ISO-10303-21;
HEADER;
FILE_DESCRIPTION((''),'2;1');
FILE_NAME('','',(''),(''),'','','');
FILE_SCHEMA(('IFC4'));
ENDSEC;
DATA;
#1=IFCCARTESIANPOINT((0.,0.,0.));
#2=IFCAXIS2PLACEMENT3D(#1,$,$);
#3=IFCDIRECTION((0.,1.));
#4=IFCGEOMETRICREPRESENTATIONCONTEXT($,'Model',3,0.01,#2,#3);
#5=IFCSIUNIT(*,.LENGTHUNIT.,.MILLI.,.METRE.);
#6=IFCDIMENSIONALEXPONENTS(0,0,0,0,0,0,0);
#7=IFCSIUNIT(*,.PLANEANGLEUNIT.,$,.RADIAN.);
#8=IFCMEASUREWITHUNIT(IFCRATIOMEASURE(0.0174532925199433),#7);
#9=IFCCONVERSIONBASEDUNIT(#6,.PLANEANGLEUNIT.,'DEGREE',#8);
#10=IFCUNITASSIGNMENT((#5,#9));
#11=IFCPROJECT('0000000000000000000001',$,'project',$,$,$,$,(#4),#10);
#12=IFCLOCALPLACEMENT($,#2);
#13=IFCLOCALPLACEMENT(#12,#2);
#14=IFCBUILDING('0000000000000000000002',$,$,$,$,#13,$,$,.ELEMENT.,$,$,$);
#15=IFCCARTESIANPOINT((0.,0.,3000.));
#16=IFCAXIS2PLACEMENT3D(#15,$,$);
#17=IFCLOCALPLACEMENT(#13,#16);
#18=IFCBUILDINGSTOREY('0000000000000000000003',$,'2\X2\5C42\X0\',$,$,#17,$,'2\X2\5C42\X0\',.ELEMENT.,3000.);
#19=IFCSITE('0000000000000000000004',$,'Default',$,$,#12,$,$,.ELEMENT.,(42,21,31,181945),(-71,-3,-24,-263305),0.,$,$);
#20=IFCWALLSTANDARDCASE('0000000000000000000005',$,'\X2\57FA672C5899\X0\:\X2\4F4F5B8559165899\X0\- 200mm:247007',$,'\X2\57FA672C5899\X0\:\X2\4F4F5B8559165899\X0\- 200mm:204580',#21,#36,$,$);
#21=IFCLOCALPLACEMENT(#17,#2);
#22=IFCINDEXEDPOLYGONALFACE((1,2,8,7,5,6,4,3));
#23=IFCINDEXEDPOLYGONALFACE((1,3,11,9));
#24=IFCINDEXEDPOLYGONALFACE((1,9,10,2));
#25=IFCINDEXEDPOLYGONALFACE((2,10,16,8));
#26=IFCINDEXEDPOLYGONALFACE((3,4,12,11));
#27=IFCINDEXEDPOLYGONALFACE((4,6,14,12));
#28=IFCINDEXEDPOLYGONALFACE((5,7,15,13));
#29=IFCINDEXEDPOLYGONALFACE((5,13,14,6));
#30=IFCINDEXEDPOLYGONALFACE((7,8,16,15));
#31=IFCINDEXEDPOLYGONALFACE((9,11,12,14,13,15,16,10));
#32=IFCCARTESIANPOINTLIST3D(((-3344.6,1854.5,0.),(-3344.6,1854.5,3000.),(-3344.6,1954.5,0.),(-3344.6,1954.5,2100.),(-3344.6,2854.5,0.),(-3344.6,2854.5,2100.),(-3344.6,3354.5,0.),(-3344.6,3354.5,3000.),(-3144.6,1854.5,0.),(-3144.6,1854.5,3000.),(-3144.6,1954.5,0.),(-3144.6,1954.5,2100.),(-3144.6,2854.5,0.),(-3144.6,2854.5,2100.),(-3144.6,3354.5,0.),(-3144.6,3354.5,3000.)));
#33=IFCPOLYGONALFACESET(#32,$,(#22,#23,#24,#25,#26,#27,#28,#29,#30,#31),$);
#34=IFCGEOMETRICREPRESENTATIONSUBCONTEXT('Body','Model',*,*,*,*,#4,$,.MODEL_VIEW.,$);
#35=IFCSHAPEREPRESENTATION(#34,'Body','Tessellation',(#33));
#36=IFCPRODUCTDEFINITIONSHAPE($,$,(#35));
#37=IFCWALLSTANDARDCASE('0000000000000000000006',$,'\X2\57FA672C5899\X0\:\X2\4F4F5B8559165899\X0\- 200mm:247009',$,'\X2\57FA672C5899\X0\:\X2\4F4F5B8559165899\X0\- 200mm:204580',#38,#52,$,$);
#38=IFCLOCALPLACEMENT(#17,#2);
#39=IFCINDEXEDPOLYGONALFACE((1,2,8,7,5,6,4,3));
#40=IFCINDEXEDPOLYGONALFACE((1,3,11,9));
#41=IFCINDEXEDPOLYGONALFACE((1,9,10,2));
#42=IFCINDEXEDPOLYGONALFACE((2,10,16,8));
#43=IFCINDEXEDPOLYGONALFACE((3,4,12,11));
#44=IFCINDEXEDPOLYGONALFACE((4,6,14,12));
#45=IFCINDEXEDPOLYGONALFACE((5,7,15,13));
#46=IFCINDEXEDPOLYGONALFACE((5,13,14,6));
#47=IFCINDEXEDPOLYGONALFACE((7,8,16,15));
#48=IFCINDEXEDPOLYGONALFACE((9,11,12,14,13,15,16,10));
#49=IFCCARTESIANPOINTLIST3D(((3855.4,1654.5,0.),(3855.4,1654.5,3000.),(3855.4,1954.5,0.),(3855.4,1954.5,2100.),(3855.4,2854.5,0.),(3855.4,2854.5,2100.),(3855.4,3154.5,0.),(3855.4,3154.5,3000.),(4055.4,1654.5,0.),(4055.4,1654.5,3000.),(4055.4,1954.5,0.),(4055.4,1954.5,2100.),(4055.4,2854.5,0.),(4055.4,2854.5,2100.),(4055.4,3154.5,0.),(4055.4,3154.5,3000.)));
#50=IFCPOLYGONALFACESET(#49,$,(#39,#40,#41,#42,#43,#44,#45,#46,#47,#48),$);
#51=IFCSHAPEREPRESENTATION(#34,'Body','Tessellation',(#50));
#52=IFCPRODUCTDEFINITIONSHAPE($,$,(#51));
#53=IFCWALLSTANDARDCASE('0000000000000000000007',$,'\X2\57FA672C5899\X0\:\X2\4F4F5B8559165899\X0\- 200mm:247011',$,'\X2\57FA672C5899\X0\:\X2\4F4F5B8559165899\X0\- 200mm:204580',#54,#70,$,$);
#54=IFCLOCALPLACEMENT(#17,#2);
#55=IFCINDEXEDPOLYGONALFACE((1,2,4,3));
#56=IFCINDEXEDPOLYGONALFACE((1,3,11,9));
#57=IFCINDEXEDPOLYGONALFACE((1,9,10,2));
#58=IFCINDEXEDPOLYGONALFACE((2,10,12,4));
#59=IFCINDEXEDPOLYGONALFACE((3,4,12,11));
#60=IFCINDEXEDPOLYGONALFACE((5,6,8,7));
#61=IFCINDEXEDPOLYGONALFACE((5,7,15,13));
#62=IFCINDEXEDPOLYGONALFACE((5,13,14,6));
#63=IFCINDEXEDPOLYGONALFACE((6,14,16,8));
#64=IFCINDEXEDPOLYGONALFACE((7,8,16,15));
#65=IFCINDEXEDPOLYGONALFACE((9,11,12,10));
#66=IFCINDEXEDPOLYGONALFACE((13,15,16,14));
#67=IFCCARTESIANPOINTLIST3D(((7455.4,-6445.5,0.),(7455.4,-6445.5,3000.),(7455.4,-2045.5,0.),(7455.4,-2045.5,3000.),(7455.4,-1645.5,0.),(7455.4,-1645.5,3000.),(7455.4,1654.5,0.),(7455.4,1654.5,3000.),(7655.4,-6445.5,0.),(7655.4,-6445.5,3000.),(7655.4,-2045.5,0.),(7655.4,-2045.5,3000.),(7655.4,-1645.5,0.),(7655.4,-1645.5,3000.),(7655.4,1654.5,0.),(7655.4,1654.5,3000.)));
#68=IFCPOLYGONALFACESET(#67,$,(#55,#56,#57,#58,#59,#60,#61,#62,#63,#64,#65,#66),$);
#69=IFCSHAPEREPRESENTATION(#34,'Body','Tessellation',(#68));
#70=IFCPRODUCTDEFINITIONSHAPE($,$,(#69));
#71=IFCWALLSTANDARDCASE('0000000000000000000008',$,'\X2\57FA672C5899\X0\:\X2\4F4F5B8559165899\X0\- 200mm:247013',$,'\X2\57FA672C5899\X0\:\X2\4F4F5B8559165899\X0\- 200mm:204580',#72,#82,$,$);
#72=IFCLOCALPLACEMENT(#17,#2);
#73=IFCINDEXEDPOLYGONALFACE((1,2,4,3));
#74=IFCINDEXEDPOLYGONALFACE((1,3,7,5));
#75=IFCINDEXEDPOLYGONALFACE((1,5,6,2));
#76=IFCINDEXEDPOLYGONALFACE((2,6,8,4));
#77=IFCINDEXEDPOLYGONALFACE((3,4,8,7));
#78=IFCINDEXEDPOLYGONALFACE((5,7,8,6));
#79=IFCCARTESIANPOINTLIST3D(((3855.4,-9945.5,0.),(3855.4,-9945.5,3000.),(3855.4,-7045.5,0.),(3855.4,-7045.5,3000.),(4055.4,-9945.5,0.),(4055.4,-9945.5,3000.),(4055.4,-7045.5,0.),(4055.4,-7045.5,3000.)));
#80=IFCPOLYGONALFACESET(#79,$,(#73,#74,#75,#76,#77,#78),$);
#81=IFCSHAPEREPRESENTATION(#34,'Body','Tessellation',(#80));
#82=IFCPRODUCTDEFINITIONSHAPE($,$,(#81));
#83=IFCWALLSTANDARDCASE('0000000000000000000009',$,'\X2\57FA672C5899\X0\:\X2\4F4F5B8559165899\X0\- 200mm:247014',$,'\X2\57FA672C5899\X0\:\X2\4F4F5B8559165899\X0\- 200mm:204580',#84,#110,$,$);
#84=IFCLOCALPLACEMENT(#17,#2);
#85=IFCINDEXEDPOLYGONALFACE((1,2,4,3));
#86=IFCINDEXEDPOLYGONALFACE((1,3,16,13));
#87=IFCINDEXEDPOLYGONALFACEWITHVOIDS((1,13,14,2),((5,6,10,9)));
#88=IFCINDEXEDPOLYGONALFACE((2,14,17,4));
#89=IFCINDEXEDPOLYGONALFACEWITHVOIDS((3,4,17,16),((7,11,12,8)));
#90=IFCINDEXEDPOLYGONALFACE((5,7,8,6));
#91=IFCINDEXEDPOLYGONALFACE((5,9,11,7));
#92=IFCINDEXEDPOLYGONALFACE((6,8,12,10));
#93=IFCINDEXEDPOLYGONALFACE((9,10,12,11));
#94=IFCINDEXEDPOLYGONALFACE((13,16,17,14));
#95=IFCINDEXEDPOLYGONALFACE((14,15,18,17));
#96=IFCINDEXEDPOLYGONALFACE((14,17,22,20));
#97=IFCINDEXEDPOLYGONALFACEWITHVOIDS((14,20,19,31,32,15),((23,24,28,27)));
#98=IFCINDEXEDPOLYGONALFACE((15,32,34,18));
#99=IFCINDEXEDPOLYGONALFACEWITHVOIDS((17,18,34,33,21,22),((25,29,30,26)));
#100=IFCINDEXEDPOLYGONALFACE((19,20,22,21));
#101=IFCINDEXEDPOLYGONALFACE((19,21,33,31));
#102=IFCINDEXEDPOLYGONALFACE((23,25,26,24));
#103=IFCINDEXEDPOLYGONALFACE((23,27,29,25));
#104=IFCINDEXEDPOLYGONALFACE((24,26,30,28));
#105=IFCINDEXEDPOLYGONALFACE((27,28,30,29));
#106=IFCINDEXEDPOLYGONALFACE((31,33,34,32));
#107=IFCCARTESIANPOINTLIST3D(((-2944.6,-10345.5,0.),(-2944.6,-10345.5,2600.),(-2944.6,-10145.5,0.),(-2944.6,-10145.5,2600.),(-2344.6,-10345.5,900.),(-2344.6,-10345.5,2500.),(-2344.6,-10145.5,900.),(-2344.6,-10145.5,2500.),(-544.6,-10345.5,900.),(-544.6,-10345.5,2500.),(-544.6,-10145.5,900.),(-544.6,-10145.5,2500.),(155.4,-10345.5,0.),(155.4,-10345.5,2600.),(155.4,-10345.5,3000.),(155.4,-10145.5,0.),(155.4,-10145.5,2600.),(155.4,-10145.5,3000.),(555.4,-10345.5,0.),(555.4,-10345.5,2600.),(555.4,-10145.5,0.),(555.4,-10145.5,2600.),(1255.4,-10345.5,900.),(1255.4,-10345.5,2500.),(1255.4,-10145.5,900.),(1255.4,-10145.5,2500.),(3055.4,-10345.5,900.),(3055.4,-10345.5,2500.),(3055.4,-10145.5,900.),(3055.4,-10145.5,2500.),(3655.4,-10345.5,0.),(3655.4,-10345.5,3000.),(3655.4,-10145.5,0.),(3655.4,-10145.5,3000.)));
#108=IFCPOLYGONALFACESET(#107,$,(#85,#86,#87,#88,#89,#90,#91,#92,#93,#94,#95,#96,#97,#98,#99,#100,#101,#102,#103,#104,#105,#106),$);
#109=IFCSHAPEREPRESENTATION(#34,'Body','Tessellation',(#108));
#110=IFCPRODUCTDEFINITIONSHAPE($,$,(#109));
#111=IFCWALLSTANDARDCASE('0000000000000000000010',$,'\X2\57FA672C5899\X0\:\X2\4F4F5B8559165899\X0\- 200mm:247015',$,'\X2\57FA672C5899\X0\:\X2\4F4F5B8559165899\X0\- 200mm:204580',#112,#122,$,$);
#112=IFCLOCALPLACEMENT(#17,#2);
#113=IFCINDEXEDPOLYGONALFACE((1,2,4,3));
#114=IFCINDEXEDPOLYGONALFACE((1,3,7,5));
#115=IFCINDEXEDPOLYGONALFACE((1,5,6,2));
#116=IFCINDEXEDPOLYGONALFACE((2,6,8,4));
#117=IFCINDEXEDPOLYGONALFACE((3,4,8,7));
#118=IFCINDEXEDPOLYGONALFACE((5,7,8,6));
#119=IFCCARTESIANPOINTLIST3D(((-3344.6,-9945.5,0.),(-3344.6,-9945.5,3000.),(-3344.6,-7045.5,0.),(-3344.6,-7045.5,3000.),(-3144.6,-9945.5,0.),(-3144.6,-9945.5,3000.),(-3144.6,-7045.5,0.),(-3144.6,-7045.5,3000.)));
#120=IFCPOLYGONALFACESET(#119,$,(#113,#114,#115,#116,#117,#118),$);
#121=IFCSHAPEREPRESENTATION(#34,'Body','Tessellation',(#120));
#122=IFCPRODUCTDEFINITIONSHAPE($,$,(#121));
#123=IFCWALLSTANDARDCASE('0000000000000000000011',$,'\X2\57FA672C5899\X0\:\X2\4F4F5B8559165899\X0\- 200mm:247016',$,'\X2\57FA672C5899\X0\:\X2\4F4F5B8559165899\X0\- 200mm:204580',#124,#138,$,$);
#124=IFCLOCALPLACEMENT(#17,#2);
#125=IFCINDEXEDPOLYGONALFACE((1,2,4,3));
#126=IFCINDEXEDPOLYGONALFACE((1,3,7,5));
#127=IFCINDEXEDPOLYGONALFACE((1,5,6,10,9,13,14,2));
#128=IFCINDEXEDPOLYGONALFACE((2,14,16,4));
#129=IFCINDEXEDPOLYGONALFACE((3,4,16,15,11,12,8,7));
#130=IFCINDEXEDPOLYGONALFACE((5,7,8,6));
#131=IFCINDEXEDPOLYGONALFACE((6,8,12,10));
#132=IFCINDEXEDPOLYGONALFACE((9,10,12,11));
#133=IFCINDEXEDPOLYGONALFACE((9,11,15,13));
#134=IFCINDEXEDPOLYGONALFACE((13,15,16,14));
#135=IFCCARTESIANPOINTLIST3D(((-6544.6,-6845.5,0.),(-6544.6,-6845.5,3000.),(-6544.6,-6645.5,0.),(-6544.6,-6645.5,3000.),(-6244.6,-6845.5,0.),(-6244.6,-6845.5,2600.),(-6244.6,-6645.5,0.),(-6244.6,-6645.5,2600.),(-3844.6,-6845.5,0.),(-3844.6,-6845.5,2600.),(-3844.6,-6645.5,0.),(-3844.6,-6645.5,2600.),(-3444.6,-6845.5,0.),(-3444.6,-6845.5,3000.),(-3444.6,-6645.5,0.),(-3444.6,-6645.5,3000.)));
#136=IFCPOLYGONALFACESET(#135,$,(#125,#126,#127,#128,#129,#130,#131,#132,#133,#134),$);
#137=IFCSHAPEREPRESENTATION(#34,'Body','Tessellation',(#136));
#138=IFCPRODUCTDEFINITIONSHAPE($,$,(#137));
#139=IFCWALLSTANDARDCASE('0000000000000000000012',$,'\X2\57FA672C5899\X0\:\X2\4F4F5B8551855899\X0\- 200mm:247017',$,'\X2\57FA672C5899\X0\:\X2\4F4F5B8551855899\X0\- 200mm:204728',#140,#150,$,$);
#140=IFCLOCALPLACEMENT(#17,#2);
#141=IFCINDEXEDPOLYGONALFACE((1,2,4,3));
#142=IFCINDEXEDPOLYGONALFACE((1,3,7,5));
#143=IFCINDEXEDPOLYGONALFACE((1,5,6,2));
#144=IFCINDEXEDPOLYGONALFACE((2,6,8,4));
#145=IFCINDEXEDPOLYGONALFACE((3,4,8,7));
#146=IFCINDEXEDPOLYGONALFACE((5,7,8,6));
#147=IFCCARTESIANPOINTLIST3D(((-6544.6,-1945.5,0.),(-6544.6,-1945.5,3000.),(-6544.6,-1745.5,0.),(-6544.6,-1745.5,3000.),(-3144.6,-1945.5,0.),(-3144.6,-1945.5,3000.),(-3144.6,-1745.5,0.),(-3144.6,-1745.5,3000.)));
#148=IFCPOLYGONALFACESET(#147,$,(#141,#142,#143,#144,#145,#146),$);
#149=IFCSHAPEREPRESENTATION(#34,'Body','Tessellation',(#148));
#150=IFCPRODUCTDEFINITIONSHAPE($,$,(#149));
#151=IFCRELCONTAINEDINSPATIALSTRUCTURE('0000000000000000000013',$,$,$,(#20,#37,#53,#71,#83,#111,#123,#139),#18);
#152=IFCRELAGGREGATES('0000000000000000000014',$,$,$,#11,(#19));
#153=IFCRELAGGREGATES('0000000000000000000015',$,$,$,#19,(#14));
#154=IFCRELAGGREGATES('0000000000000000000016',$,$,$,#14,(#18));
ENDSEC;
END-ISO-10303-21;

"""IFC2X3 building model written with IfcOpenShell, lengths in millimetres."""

from ifc_helpers import new_model, entity, si_unit, converted_unit, direction, frame, frame_2d, origin, place, context, subcontext, project, spatial, polyline, rectangle, extrude, clip, bounded_halfspace, element, save


model = new_model("IFC2X3")

# Units and contexts
model_context = context("Model", 3, precision=0.01, world=origin(), true_north=direction((0.0, 1.0)))
body_context = subcontext(model_context, "Body", "Model", "MODEL_VIEW")
ifc_project = project(units=[si_unit("LENGTHUNIT", "METRE", prefix="MILLI"), converted_unit("PLANEANGLEUNIT", "DEGREE", entity("IfcRatioMeasure", 0.0174532925199433), si_unit("PLANEANGLEUNIT", "RADIAN"), dimensions=[0, 0, 0, 0, 0, 0, 0])], contexts=[model_context])

# Site, building, storey
site_placement = place(None, origin())
site = spatial("IfcSite", under=ifc_project, at=site_placement, Name="Default", CompositionType="ELEMENT", RefLatitude=(42, 21, 31, 181945), RefLongitude=(-71, -3, -24, -263305), RefElevation=0.0)
building_placement = place(site_placement, origin())
building = spatial("IfcBuilding", under=site, at=building_placement, CompositionType="ELEMENT")
storey_placement = place(building_placement, frame((0.0, 0.0, 3000.0)))
storey = spatial("IfcBuildingStorey", under=building, at=storey_placement, Name="2层", LongName="2层", CompositionType="ELEMENT", Elevation=3000.0)

# Walls, openings
wall_1_placement = place(storey_placement, frame((-3244.6, 1854.5, 0.0), z_axis=(0.0, 0.0, 1.0), x_axis=(0.0, 1.0, 0.0)))
wall_1 = element("IfcWallStandardCase", 1, at=wall_1_placement, inside=storey, Name="基本墙:住宅外墙- 200mm:247007", ObjectType="基本墙:住宅外墙- 200mm:204580", context=body_context, shape_type="SweptSolid", body=[
    extrude(rectangle(XDim=1500.0, YDim=200.0, at=frame_2d((750.0, 0.0), x_axis=(-1.0, 0.0))), origin(), (0.0, 0.0, 1.0), 3000.0),
])
opening_1_placement = place(wall_1_placement, frame((100.0, -100.0, 0.0)))
element("IfcOpeningElement", 2, at=opening_1_placement, cuts=wall_1, ObjectType="Opening", context=body_context, shape_type="SweptSolid", body=[
    extrude(rectangle(XDim=2100.0, YDim=900.0, at=frame_2d((1050.0, 450.0), x_axis=(1.0, 0.0))), frame((0.0, 0.0, 0.0), z_axis=(0.0, 1.0, 0.0), x_axis=(0.0, 0.0, 1.0)), (0.0, 0.0, 1.0), 200.0),
])
wall_2_placement = place(storey_placement, frame((3955.4, 3154.5, 0.0), z_axis=(0.0, 0.0, 1.0), x_axis=(0.0, -1.0, 0.0)))
wall_2 = element("IfcWallStandardCase", 3, at=wall_2_placement, inside=storey, Name="基本墙:住宅外墙- 200mm:247009", ObjectType="基本墙:住宅外墙- 200mm:204580", context=body_context, shape_type="SweptSolid", body=[
    extrude(rectangle(XDim=1500.0, YDim=200.0, at=frame_2d((750.0, 0.0), x_axis=(-1.0, 0.0))), origin(), (0.0, 0.0, 1.0), 3000.0),
])
opening_2_placement = place(wall_2_placement, frame((300.0, -100.0, 0.0)))
element("IfcOpeningElement", 4, at=opening_2_placement, cuts=wall_2, ObjectType="Opening", context=body_context, shape_type="SweptSolid", body=[
    extrude(rectangle(XDim=2100.0, YDim=900.0, at=frame_2d((1050.0, 450.0), x_axis=(1.0, 0.0))), frame((0.0, 0.0, 0.0), z_axis=(0.0, 1.0, 0.0), x_axis=(0.0, 0.0, 1.0)), (0.0, 0.0, 1.0), 200.0),
])
wall_3_placement = place(storey_placement, frame((7555.4, 1654.5, 0.0), z_axis=(0.0, 0.0, 1.0), x_axis=(0.0, -1.0, 0.0)))
wall_3 = element("IfcWallStandardCase", 5, at=wall_3_placement, inside=storey, Name="基本墙:住宅外墙- 200mm:247011", ObjectType="基本墙:住宅外墙- 200mm:204580", context=body_context, shape_type="Clipping", body=[
    clip(extrude(rectangle(XDim=8100.0, YDim=200.0, at=frame_2d((4050.0, 0.0), x_axis=(-1.0, 0.0))), origin(), (0.0, 0.0, 1.0), 3000.0), bounded_halfspace(frame((8100.0, -100.0, 3000.0), z_axis=(1.0, 0.0, 0.0), x_axis=(0.0, 0.0, -1.0)), False, frame((8100.0, -100.0, 3000.0), z_axis=(1.0, 0.0, 0.0), x_axis=(0.0, 0.0, -1.0)), polyline([(0.0, 0.0), (3000.0, 0.0), (3000.0, 200.0), (0.0, 200.0), (0.0, 0.0)]))),
])
opening_3_placement = place(storey_placement, frame((7555.4, 1654.5, 0.0), z_axis=(0.0, 0.0, 1.0), x_axis=(0.0, -1.0, 0.0)))
element("IfcOpeningElement", 6, at=opening_3_placement, cuts=wall_3, ObjectType="Opening", context=body_context, shape_type="SweptSolid", body=[
    extrude(rectangle(XDim=3000.0, YDim=200.0, at=frame_2d((0.0, 0.0), x_axis=(1.0, 0.0))), frame((3700.0, 0.0, 1500.0), z_axis=(-1.0, 0.0, 0.0), x_axis=(0.0, 0.0, 1.0)), (0.0, 0.0, 1.0), 400.0),
])

# Wall
wall_4_placement = place(storey_placement, frame((3955.4, -7045.5, 0.0), z_axis=(0.0, 0.0, 1.0), x_axis=(0.0, -1.0, 0.0)))
element("IfcWallStandardCase", 7, at=wall_4_placement, inside=storey, Name="基本墙:住宅外墙- 200mm:247013", ObjectType="基本墙:住宅外墙- 200mm:204580", context=body_context, shape_type="Clipping", body=[
    clip(clip(extrude(rectangle(XDim=2900.0, YDim=200.0, at=frame_2d((1450.0, 0.0), x_axis=(-1.0, 0.0))), origin(), (0.0, 0.0, 1.0), 3000.0), bounded_halfspace(frame((0.0, -100.0, 0.0), z_axis=(-1.0, 0.0, 0.0), x_axis=(0.0, 0.0, -1.0)), False, frame((0.0, -100.0, 0.0), z_axis=(-1.0, 0.0, 0.0), x_axis=(0.0, 0.0, -1.0)), polyline([(0.0, 0.0), (-3000.0, 0.0), (-3000.0, -200.0), (0.0, -200.0), (0.0, 0.0)]))), bounded_halfspace(frame((2900.0, -100.0, 3000.0), z_axis=(1.0, 0.0, 0.0), x_axis=(0.0, 0.0, -1.0)), False, frame((2900.0, -100.0, 3000.0), z_axis=(1.0, 0.0, 0.0), x_axis=(0.0, 0.0, -1.0)), polyline([(0.0, 0.0), (3000.0, 0.0), (3000.0, 200.0), (0.0, 200.0), (0.0, 0.0)]))),
])

# Wall, openings
wall_5_placement = place(storey_placement, frame((3655.4, -10245.5, 0.0), z_axis=(0.0, 0.0, 1.0), x_axis=(-1.0, 0.0, 0.0)))
wall_5 = element("IfcWallStandardCase", 8, at=wall_5_placement, inside=storey, Name="基本墙:住宅外墙- 200mm:247014", ObjectType="基本墙:住宅外墙- 200mm:204580", context=body_context, shape_type="Clipping", body=[
    clip(clip(clip(extrude(rectangle(XDim=6600.0, YDim=200.0, at=frame_2d((3300.0, 0.0), x_axis=(-1.0, 0.0))), origin(), (0.0, 0.0, 1.0), 3000.0), bounded_halfspace(frame((0.0, -100.0, 0.0), z_axis=(-1.0, 0.0, 0.0), x_axis=(0.0, 0.0, -1.0)), False, frame((0.0, -100.0, 0.0), z_axis=(-1.0, 0.0, 0.0), x_axis=(0.0, 0.0, -1.0)), polyline([(0.0, 0.0), (-3000.0, 0.0), (-3000.0, -200.0), (0.0, -200.0), (0.0, 0.0)]))), bounded_halfspace(frame((6600.0, -100.0, 0.0), z_axis=(-1.0, 0.0, 0.0), x_axis=(0.0, 0.0, -1.0)), True, frame((6600.0, -100.0, 0.0), z_axis=(-1.0, 0.0, 0.0), x_axis=(0.0, 0.0, -1.0)), polyline([(0.0, 0.0), (-2600.0, 0.0), (-2600.0, -200.0), (0.0, -200.0), (0.0, 0.0)]))), bounded_halfspace(frame((3500.0, -100.0, 2600.0), z_axis=(0.0, 0.0, -1.0), x_axis=(1.0, 0.0, 0.0)), True, frame((3500.0, -100.0, 2600.0), z_axis=(0.0, 0.0, -1.0), x_axis=(1.0, 0.0, 0.0)), polyline([(0.0, 0.0), (0.0, -200.0), (3100.0, -200.0), (3100.0, 0.0), (0.0, 0.0)]))),
])
opening_4_placement = place(wall_5_placement, frame((2400.0, 100.0, 900.0)))
element("IfcOpeningElement", 9, at=opening_4_placement, cuts=wall_5, ObjectType="Opening", context=body_context, shape_type="SweptSolid", body=[
    extrude(rectangle(XDim=1600.0, YDim=1800.0, at=frame_2d((800.0, 900.0), x_axis=(1.0, 0.0))), frame((0.0, 0.0, 0.0), z_axis=(0.0, -1.0, 0.0), x_axis=(0.0, 0.0, 1.0)), (0.0, 0.0, 1.0), 200.0),
])
opening_5_placement = place(wall_5_placement, frame((6000.0, 100.0, 900.0)))
element("IfcOpeningElement", 10, at=opening_5_placement, cuts=wall_5, ObjectType="Opening", context=body_context, shape_type="SweptSolid", body=[
    extrude(rectangle(XDim=1600.0, YDim=1800.0, at=frame_2d((800.0, 900.0), x_axis=(1.0, 0.0))), frame((0.0, 0.0, 0.0), z_axis=(0.0, -1.0, 0.0), x_axis=(0.0, 0.0, 1.0)), (0.0, 0.0, 1.0), 200.0),
])
opening_6_placement = place(storey_placement, frame((3655.4, -10245.5, 0.0), z_axis=(0.0, 0.0, 1.0), x_axis=(-1.0, 0.0, 0.0)))
element("IfcOpeningElement", 11, at=opening_6_placement, cuts=wall_5, ObjectType="Opening", context=body_context, shape_type="SweptSolid", body=[
    extrude(rectangle(XDim=2600.0, YDim=200.0, at=frame_2d((0.0, 0.0), x_axis=(0.0, 1.0))), frame((3500.0, 0.0, 1300.0), z_axis=(-1.0, 0.0, 0.0), x_axis=(0.0, -1.0, 0.0)), (0.0, 0.0, 1.0), 400.0),
])

# Wall
wall_6_placement = place(storey_placement, frame((-3244.6, -9945.5, 0.0), z_axis=(0.0, 0.0, 1.0), x_axis=(0.0, 1.0, 0.0)))
element("IfcWallStandardCase", 12, at=wall_6_placement, inside=storey, Name="基本墙:住宅外墙- 200mm:247015", ObjectType="基本墙:住宅外墙- 200mm:204580", context=body_context, shape_type="Clipping", body=[
    clip(clip(extrude(rectangle(XDim=2900.0, YDim=200.0, at=frame_2d((1450.0, 0.0), x_axis=(-1.0, 0.0))), origin(), (0.0, 0.0, 1.0), 3000.0), bounded_halfspace(frame((0.0, -100.0, 0.0), z_axis=(1.0, 0.0, 0.0), x_axis=(0.0, 0.0, -1.0)), True, frame((0.0, -100.0, 0.0), z_axis=(1.0, 0.0, 0.0), x_axis=(0.0, 0.0, -1.0)), polyline([(0.0, 0.0), (0.0, 200.0), (-3000.0, 200.0), (-3000.0, 0.0), (0.0, 0.0)]))), bounded_halfspace(frame((2900.0, -100.0, 3000.0), z_axis=(-1.0, 0.0, 0.0), x_axis=(0.0, 0.0, -1.0)), True, frame((2900.0, -100.0, 3000.0), z_axis=(-1.0, 0.0, 0.0), x_axis=(0.0, 0.0, -1.0)), polyline([(0.0, 0.0), (0.0, -200.0), (3000.0, -200.0), (3000.0, 0.0), (0.0, 0.0)]))),
])

# Wall, opening
wall_7_placement = place(storey_placement, frame((-3444.6, -6745.5, 0.0), z_axis=(0.0, 0.0, 1.0), x_axis=(-1.0, 0.0, 0.0)))
wall_7 = element("IfcWallStandardCase", 13, at=wall_7_placement, inside=storey, Name="基本墙:住宅外墙- 200mm:247016", ObjectType="基本墙:住宅外墙- 200mm:204580", context=body_context, shape_type="Clipping", body=[
    clip(clip(extrude(rectangle(XDim=3100.0, YDim=200.0, at=frame_2d((1550.0, 0.0), x_axis=(-1.0, 0.0))), origin(), (0.0, 0.0, 1.0), 3000.0), bounded_halfspace(frame((0.0, -100.0, 0.0), z_axis=(1.0, 0.0, 0.0), x_axis=(0.0, 0.0, -1.0)), True, frame((0.0, -100.0, 0.0), z_axis=(1.0, 0.0, 0.0), x_axis=(0.0, 0.0, -1.0)), polyline([(0.0, 0.0), (0.0, 200.0), (-3000.0, 200.0), (-3000.0, 0.0), (0.0, 0.0)]))), bounded_halfspace(frame((3100.0, -100.0, 3000.0), z_axis=(-1.0, 0.0, 0.0), x_axis=(0.0, 0.0, -1.0)), True, frame((3100.0, -100.0, 3000.0), z_axis=(-1.0, 0.0, 0.0), x_axis=(0.0, 0.0, -1.0)), polyline([(0.0, 0.0), (0.0, -200.0), (3000.0, -200.0), (3000.0, 0.0), (0.0, 0.0)]))),
])
opening_7_placement = place(wall_7_placement, frame((400.0, -100.0, 0.0)))
element("IfcOpeningElement", 14, at=opening_7_placement, cuts=wall_7, ObjectType="Opening", context=body_context, shape_type="SweptSolid", body=[
    extrude(rectangle(XDim=2600.0, YDim=2400.0, at=frame_2d((1300.0, 1200.0), x_axis=(1.0, 0.0))), frame((0.0, 0.0, 0.0), z_axis=(0.0, 1.0, 0.0), x_axis=(0.0, 0.0, 1.0)), (0.0, 0.0, 1.0), 200.0),
])

# Wall
wall_8_placement = place(storey_placement, frame((-6544.6, -1845.5, 0.0)))
element("IfcWallStandardCase", 15, at=wall_8_placement, inside=storey, Name="基本墙:住宅内墙- 200mm:247017", ObjectType="基本墙:住宅内墙- 200mm:204728", context=body_context, shape_type="Clipping", body=[
    clip(extrude(rectangle(XDim=3400.0, YDim=200.0, at=frame_2d((1700.0, 0.0), x_axis=(-1.0, 0.0))), origin(), (0.0, 0.0, 1.0), 3000.0), bounded_halfspace(frame((0.0, -100.0, 0.0), z_axis=(1.0, 0.0, 0.0), x_axis=(0.0, 0.0, -1.0)), True, frame((0.0, -100.0, 0.0), z_axis=(1.0, 0.0, 0.0), x_axis=(0.0, 0.0, -1.0)), polyline([(0.0, 0.0), (0.0, 200.0), (-3000.0, 200.0), (-3000.0, 0.0), (0.0, 0.0)]))),
])

save(model, "model.ifc")
